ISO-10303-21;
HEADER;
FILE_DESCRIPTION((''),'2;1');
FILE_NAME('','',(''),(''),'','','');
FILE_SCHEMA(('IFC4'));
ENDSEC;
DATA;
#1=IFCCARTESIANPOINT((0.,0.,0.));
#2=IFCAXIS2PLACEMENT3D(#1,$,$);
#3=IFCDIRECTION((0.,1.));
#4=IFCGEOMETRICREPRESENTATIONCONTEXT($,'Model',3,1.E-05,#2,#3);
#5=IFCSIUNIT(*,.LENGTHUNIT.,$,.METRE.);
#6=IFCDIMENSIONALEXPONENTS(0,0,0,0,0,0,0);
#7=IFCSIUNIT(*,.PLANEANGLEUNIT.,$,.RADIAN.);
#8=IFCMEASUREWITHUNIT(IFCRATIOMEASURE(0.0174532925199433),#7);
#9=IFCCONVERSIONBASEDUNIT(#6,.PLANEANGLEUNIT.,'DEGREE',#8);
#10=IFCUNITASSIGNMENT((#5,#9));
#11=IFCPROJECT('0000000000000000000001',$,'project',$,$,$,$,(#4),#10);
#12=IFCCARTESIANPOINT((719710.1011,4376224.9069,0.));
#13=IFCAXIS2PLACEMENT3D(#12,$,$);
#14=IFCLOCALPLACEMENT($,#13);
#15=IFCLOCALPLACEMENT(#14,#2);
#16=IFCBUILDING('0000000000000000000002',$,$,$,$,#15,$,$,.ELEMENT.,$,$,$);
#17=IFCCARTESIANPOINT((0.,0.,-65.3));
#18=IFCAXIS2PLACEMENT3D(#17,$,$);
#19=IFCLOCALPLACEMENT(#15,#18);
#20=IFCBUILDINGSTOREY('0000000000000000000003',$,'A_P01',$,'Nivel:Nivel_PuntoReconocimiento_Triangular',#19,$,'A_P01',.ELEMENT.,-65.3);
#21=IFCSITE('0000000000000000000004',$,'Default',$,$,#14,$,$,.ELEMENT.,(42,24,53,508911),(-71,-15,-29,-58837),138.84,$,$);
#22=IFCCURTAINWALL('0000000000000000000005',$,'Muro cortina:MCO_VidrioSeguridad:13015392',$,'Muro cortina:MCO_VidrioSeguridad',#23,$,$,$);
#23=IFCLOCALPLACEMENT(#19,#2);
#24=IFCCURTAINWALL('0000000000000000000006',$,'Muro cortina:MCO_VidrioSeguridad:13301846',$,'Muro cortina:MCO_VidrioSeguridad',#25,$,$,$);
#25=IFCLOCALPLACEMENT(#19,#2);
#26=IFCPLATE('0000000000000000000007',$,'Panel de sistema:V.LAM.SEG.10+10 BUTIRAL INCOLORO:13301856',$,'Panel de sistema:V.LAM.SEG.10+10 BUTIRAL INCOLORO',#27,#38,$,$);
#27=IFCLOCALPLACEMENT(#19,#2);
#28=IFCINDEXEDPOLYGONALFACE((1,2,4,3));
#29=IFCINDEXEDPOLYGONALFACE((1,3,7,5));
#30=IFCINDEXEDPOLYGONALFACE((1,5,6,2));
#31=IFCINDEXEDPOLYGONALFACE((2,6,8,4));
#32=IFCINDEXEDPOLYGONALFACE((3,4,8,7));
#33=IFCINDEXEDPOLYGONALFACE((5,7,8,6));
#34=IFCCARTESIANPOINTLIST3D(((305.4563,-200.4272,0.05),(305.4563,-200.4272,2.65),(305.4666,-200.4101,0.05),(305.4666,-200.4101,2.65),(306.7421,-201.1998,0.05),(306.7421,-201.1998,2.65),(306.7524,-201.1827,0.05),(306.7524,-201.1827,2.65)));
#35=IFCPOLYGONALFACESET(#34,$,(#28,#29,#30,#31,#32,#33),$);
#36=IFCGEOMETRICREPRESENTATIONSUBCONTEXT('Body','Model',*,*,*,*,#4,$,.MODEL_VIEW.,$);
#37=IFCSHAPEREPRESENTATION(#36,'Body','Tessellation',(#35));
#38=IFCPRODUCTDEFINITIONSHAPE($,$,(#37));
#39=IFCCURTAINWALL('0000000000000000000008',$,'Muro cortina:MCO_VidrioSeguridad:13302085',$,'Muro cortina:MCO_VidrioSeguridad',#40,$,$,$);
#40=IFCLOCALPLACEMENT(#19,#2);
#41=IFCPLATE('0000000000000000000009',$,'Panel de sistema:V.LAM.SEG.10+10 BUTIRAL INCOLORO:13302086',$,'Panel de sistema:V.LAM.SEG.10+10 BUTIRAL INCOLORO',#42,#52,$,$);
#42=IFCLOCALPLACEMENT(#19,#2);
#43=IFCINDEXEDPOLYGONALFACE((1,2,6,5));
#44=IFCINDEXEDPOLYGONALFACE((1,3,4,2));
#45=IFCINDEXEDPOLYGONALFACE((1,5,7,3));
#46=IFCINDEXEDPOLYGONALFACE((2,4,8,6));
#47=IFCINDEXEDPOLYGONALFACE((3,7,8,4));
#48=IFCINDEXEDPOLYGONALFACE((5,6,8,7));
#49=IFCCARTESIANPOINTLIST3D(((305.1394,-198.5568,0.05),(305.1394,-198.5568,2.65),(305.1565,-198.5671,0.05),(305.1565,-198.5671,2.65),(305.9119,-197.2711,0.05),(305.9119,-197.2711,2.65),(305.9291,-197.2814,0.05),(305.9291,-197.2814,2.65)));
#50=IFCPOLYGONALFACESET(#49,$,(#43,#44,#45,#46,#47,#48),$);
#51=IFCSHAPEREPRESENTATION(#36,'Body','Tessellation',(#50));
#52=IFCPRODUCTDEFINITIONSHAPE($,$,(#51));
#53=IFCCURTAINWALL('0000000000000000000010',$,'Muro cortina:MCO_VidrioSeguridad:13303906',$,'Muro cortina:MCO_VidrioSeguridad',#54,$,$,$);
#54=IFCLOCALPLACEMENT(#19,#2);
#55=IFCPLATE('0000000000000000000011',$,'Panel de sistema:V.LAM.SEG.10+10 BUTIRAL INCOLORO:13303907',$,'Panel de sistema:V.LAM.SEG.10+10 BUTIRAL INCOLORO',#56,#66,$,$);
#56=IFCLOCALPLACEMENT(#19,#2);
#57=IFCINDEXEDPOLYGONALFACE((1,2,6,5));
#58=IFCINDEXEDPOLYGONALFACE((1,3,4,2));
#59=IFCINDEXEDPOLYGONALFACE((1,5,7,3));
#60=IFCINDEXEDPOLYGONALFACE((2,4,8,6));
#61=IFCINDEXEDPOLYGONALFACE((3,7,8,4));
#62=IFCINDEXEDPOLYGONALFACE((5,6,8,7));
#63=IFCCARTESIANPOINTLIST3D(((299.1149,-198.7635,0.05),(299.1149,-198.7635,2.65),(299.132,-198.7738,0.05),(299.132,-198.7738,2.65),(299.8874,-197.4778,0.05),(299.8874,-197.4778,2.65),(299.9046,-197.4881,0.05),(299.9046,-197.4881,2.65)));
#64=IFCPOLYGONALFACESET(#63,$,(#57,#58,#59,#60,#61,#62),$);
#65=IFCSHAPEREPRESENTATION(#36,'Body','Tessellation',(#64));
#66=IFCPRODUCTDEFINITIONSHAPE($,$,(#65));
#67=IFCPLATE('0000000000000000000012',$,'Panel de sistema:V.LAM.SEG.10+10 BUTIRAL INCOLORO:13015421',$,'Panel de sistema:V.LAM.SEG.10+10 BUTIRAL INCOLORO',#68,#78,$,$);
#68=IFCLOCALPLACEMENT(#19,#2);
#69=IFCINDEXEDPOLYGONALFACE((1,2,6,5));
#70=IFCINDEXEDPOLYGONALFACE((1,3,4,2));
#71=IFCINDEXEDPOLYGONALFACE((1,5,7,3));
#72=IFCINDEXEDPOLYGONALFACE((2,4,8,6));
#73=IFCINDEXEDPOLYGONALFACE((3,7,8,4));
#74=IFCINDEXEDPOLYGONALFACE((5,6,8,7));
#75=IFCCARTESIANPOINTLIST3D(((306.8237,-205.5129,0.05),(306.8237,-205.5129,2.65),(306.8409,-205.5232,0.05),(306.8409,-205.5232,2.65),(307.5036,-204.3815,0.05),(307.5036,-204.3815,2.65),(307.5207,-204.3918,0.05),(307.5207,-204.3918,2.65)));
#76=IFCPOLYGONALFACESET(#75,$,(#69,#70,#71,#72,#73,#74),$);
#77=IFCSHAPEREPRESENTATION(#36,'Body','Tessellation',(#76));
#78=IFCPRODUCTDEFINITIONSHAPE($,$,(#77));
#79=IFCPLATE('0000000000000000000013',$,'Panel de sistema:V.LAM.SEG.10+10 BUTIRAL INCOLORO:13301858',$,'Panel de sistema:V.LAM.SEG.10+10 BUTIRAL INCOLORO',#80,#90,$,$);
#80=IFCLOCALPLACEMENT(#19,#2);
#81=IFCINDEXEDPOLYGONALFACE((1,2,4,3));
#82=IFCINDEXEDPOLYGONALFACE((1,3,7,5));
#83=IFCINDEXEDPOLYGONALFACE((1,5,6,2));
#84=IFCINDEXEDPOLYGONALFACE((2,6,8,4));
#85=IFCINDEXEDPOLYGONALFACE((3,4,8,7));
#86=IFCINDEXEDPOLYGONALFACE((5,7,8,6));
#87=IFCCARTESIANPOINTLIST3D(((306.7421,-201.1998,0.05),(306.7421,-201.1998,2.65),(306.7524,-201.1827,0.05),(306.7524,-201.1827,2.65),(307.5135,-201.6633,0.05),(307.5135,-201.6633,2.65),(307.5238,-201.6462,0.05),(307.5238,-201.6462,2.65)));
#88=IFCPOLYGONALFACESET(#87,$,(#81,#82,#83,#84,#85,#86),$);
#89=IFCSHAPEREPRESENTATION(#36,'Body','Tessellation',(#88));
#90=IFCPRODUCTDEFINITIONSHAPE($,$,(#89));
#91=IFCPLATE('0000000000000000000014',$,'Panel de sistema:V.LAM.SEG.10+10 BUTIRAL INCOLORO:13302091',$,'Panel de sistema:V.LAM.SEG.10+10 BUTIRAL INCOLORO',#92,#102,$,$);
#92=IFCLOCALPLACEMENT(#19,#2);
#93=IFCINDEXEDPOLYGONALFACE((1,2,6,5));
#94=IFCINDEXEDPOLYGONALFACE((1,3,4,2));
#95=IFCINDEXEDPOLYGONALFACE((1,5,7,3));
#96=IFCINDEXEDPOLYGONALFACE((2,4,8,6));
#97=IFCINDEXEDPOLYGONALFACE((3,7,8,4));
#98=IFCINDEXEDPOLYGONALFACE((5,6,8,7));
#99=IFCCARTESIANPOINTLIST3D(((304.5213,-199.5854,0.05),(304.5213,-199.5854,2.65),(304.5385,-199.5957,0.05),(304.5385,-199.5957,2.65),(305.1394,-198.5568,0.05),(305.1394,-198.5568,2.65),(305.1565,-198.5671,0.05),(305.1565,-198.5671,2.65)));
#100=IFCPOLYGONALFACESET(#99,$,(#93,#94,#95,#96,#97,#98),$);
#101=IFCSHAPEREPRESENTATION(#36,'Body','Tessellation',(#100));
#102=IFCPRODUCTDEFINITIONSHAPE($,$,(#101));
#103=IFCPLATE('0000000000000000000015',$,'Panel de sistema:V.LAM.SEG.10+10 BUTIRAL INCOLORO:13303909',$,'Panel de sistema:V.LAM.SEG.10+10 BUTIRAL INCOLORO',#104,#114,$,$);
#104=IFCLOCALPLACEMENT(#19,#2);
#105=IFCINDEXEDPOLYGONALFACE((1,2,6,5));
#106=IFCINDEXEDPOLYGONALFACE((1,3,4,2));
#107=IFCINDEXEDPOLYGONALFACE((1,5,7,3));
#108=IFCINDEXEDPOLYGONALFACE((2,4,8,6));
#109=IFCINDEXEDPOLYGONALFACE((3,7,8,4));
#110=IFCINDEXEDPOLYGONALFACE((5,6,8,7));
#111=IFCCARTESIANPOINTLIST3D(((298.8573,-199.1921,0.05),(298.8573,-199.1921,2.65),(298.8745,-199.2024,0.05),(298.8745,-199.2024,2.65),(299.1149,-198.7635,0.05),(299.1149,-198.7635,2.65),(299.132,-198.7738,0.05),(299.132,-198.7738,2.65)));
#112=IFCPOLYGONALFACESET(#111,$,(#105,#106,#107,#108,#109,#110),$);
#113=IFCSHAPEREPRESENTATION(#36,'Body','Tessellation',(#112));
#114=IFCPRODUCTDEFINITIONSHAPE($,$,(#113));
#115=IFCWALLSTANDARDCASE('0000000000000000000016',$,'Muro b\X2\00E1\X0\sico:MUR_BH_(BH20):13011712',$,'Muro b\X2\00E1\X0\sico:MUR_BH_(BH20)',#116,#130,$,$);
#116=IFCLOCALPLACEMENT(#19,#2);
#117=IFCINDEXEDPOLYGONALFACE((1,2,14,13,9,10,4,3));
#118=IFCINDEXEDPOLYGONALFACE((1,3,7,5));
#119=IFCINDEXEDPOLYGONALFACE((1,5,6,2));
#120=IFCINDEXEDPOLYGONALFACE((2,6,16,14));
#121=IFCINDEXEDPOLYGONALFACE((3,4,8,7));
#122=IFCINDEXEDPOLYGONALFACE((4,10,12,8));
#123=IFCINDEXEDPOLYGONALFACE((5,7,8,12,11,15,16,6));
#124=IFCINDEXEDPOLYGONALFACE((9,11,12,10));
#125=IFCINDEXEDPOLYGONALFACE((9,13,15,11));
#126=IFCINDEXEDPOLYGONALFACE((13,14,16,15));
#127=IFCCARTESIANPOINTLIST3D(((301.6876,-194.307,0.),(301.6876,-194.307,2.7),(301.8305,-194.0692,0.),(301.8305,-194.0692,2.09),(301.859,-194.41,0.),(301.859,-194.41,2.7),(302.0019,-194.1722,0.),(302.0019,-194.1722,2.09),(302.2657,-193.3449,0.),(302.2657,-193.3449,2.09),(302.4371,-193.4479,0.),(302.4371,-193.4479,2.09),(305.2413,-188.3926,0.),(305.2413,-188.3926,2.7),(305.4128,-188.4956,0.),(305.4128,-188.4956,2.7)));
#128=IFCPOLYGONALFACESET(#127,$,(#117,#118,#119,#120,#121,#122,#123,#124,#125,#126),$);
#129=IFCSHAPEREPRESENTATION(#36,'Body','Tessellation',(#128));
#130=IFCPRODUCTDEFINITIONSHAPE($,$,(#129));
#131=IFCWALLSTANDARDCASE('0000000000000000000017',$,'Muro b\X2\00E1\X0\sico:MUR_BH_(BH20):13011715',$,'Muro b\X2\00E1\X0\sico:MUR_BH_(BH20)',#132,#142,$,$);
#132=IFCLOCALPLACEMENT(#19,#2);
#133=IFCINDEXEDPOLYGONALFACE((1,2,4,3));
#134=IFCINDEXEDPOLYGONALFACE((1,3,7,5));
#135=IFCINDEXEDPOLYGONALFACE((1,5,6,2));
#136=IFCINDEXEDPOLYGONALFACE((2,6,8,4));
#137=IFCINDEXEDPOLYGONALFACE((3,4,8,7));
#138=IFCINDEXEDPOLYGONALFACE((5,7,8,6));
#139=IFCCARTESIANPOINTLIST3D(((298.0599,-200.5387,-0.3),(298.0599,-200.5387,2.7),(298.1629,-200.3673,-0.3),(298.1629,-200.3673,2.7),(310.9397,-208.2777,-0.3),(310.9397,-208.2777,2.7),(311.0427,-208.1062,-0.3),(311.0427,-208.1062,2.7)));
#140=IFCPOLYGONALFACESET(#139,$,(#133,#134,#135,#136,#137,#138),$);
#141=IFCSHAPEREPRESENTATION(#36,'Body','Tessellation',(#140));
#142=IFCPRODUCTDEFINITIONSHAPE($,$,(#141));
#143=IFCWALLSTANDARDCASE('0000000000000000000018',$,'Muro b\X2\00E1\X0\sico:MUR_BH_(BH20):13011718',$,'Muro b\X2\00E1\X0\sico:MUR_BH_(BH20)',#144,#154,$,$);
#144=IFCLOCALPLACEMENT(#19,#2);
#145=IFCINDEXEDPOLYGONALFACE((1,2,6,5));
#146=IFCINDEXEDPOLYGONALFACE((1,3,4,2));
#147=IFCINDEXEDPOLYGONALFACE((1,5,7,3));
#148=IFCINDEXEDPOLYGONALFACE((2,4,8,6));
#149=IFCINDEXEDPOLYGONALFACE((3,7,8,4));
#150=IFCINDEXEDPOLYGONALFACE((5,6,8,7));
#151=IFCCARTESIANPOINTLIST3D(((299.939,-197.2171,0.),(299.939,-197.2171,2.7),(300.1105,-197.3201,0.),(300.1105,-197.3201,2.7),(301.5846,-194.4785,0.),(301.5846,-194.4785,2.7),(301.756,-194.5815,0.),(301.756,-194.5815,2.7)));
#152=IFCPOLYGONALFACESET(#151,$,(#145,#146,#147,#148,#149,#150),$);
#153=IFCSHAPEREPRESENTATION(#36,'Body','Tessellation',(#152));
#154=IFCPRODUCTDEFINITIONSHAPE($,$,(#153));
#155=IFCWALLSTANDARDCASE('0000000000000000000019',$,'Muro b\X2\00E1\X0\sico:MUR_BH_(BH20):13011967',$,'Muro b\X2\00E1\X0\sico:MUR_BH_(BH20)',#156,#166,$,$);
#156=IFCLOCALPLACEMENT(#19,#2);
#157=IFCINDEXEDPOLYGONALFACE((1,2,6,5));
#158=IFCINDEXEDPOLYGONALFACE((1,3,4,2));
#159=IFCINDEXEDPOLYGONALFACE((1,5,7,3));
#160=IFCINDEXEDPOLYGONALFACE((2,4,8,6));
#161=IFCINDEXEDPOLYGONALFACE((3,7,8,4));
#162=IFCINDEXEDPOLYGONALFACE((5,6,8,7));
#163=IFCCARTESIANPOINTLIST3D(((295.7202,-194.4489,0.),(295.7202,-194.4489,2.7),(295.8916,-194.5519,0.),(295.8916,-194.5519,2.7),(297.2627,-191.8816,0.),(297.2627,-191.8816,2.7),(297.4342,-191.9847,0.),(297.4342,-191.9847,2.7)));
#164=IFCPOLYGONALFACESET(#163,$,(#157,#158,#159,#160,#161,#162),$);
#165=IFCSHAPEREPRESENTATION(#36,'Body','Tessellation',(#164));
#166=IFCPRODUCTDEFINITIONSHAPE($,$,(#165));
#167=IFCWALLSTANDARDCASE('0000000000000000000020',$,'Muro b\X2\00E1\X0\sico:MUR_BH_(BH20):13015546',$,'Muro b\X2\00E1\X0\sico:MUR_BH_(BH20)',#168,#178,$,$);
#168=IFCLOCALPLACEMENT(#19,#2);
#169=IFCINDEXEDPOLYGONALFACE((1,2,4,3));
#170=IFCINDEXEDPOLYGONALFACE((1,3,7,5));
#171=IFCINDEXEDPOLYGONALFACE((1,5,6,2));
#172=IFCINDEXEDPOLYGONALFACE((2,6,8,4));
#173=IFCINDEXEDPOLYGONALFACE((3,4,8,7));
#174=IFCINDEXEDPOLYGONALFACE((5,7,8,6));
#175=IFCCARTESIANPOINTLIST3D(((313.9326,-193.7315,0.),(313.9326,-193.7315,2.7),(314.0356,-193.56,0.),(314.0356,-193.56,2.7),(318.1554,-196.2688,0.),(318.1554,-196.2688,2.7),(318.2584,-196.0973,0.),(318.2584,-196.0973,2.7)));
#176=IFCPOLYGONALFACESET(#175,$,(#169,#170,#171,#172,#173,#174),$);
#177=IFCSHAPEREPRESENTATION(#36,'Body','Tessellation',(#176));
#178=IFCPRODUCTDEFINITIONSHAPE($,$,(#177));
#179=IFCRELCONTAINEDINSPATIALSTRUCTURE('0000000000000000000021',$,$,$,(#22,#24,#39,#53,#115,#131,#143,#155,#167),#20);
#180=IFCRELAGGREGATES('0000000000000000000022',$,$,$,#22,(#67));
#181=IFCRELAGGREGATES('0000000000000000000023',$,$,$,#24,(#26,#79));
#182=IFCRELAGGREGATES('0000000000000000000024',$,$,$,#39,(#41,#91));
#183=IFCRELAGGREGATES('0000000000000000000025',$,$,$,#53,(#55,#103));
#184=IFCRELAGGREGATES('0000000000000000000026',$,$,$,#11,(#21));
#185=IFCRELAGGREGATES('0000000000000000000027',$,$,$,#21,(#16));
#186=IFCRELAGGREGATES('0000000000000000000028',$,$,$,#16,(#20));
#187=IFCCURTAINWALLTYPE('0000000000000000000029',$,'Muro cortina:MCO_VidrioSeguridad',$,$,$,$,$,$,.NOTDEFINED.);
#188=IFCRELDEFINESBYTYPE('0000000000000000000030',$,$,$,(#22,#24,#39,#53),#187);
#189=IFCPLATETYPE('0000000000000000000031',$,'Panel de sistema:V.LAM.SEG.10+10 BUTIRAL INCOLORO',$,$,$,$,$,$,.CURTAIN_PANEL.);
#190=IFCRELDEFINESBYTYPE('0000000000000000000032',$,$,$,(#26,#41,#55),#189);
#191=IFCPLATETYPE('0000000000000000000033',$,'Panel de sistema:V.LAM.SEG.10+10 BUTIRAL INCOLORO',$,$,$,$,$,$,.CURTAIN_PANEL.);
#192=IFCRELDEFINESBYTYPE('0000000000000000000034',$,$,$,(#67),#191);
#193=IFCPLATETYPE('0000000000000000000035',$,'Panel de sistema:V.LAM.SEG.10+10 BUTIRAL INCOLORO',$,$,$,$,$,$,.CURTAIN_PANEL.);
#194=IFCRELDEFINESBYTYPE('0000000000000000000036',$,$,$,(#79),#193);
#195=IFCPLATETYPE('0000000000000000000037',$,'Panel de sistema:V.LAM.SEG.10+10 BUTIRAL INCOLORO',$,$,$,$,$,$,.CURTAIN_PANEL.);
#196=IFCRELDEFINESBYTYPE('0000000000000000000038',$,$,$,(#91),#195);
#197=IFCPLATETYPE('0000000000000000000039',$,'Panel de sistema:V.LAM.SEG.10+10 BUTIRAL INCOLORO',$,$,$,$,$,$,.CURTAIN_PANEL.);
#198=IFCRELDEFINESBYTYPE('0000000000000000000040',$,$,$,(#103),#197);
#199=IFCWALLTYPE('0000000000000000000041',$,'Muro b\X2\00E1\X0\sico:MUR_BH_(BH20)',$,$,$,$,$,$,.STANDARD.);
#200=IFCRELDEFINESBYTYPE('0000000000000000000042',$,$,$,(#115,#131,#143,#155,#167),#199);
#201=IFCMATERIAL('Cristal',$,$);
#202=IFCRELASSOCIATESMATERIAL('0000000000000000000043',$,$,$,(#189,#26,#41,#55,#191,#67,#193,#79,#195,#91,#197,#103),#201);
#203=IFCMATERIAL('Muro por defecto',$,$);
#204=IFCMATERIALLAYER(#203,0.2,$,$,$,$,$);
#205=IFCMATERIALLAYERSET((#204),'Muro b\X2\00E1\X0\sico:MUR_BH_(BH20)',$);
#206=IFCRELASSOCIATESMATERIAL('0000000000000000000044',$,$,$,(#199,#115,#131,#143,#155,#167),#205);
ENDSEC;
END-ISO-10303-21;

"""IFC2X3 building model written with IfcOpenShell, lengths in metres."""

from ifc_helpers import new_model, entity, si_unit, converted_unit, direction, frame, frame_2d, origin, origin_2d_with_axis, place, context, subcontext, project, spatial, rectangle, extrude, source, transform, mapped, material, layer, layer_set, layer_usage, type_object, type_shapes, element, aggregate, save


model = new_model("IFC2X3")

# Units and contexts
model_context = context("Model", 3, precision=1e-05, world=origin(), true_north=direction((0.0, 1.0)))
body_context = subcontext(model_context, "Body", "Model", "MODEL_VIEW")
ifc_project = project(units=[si_unit("LENGTHUNIT", "METRE"), converted_unit("PLANEANGLEUNIT", "DEGREE", entity("IfcRatioMeasure", 0.0174532925199433), si_unit("PLANEANGLEUNIT", "RADIAN"), dimensions=[0, 0, 0, 0, 0, 0, 0])], contexts=[model_context])

# Site, building, storey
site_placement = place(None, frame((719710.1011, 4376224.9069, 0.0)))
site = spatial("IfcSite", under=ifc_project, at=site_placement, Name="Default", CompositionType="ELEMENT", RefLatitude=(42, 24, 53, 508911), RefLongitude=(-71, -15, -29, -58837), RefElevation=138.84)
building_placement = place(site_placement, origin())
building = spatial("IfcBuilding", under=site, at=building_placement, CompositionType="ELEMENT")
storey_placement = place(building_placement, frame((0.0, 0.0, -65.3)))
storey = spatial("IfcBuildingStorey", under=building, at=storey_placement, Name="A_P01", ObjectType="Nivel:Nivel_PuntoReconocimiento_Triangular", LongName="A_P01", CompositionType="ELEMENT", Elevation=-65.3)

# Curtain walls, plate
curtain_wall_type = type_object("IfcCurtainWallType", Name="Muro cortina:MCO_VidrioSeguridad", PredefinedType="NOTDEFINED")
ifc_material_1 = material(Name="Cristal")
plate_type_1 = type_object("IfcPlateType", Name="Panel de sistema:V.LAM.SEG.10+10 BUTIRAL INCOLORO", PredefinedType="CURTAIN_PANEL", material=ifc_material_1)
shared_shape_1 = source(origin(), body_context, "Body", "SweptSolid", [
    extrude(rectangle(XDim=0.02, YDim=1.5, at=origin_2d_with_axis()), frame((0.0, 0.0, 0.0), z_axis=(0.0, 0.0, 1.0), x_axis=(0.0, 1.0, 0.0)), (0.0, 0.0, 1.0), 2.6),
])
type_shapes(plate_type_1, [shared_shape_1])
curtain_wall_1_placement = place(storey_placement, frame((0.0, 0.0, 65.3)))
curtain_wall_1 = element("IfcCurtainWall", 1, at=curtain_wall_1_placement, inside=storey, type_object=curtain_wall_type, Name="Muro cortina:MCO_VidrioSeguridad:13015392", ObjectType="Muro cortina:MCO_VidrioSeguridad")
curtain_wall_2_placement = place(storey_placement, frame((0.0, 0.0, 65.3)))
curtain_wall_2 = element("IfcCurtainWall", 2, at=curtain_wall_2_placement, inside=storey, type_object=curtain_wall_type, Name="Muro cortina:MCO_VidrioSeguridad:13301846", ObjectType="Muro cortina:MCO_VidrioSeguridad")
plate_1_placement = place(curtain_wall_2_placement, frame((306.1043, -200.8049, -65.25), z_axis=(0.0, 0.0, 1.0), x_axis=(0.857167, -0.515038, 0.0)))
plate_1 = element("IfcPlate", 3, at=plate_1_placement, type_object=plate_type_1, material=ifc_material_1, Name="Panel de sistema:V.LAM.SEG.10+10 BUTIRAL INCOLORO:13301856", ObjectType="Panel de sistema:V.LAM.SEG.10+10 BUTIRAL INCOLORO", context=body_context, shape_type="MappedRepresentation", body=[
    mapped(shared_shape_1, transform((0.0, 0.0, 0.0), scale=1.0)),
])

# Curtain walls, plates
curtain_wall_3_placement = place(storey_placement, frame((0.0, 0.0, 65.3)))
curtain_wall_3 = element("IfcCurtainWall", 4, at=curtain_wall_3_placement, inside=storey, type_object=curtain_wall_type, Name="Muro cortina:MCO_VidrioSeguridad:13302085", ObjectType="Muro cortina:MCO_VidrioSeguridad")
plate_2_placement = place(curtain_wall_3_placement, frame((305.5342, -197.9191, -65.25), z_axis=(0.0, 0.0, 1.0), x_axis=(-0.515038, -0.857167, 0.0)))
plate_2 = element("IfcPlate", 5, at=plate_2_placement, type_object=plate_type_1, material=ifc_material_1, Name="Panel de sistema:V.LAM.SEG.10+10 BUTIRAL INCOLORO:13302086", ObjectType="Panel de sistema:V.LAM.SEG.10+10 BUTIRAL INCOLORO", context=body_context, shape_type="MappedRepresentation", body=[
    mapped(shared_shape_1, transform((0.0, 0.0, 0.0), scale=1.0)),
])
curtain_wall_4_placement = place(storey_placement, frame((0.0, 0.0, 65.3)))
curtain_wall_4 = element("IfcCurtainWall", 6, at=curtain_wall_4_placement, inside=storey, type_object=curtain_wall_type, Name="Muro cortina:MCO_VidrioSeguridad:13303906", ObjectType="Muro cortina:MCO_VidrioSeguridad")
plate_3_placement = place(curtain_wall_4_placement, frame((299.5097, -198.1258, -65.25), z_axis=(0.0, 0.0, 1.0), x_axis=(-0.515038, -0.857167, 0.0)))
plate_3 = element("IfcPlate", 7, at=plate_3_placement, type_object=plate_type_1, material=ifc_material_1, Name="Panel de sistema:V.LAM.SEG.10+10 BUTIRAL INCOLORO:13303907", ObjectType="Panel de sistema:V.LAM.SEG.10+10 BUTIRAL INCOLORO", context=body_context, shape_type="MappedRepresentation", body=[
    mapped(shared_shape_1, transform((0.0, 0.0, 0.0), scale=1.0)),
])

# Plates
plate_type_2 = type_object("IfcPlateType", Name="Panel de sistema:V.LAM.SEG.10+10 BUTIRAL INCOLORO", PredefinedType="CURTAIN_PANEL", material=ifc_material_1)
shared_shape_2 = source(origin(), body_context, "Body", "SweptSolid", [
    extrude(rectangle(XDim=0.02, YDim=1.32, at=origin_2d_with_axis()), frame((0.0, 0.0, 0.0), z_axis=(0.0, 0.0, 1.0), x_axis=(0.0, 1.0, 0.0)), (0.0, 0.0, 1.0), 2.6),
])
type_shapes(plate_type_2, [shared_shape_2])
plate_4_placement = place(curtain_wall_1_placement, frame((307.1722, -204.9523, -65.25), z_axis=(0.0, 0.0, 1.0), x_axis=(-0.515038, -0.857167, 0.0)))
plate_4 = element("IfcPlate", 8, at=plate_4_placement, type_object=plate_type_2, material=ifc_material_1, Name="Panel de sistema:V.LAM.SEG.10+10 BUTIRAL INCOLORO:13015421", ObjectType="Panel de sistema:V.LAM.SEG.10+10 BUTIRAL INCOLORO", context=body_context, shape_type="MappedRepresentation", body=[
    mapped(shared_shape_2, transform((0.0, 0.0, 0.0), scale=1.0)),
])
aggregate(curtain_wall_1, [plate_4])
plate_type_3 = type_object("IfcPlateType", Name="Panel de sistema:V.LAM.SEG.10+10 BUTIRAL INCOLORO", PredefinedType="CURTAIN_PANEL", material=ifc_material_1)
shared_shape_3 = source(origin(), body_context, "Body", "SweptSolid", [
    extrude(rectangle(XDim=0.02, YDim=0.9, at=origin_2d_with_axis()), frame((0.0, 0.0, 0.0), z_axis=(0.0, 0.0, 1.0), x_axis=(0.0, 1.0, 0.0)), (0.0, 0.0, 1.0), 2.6),
])
type_shapes(plate_type_3, [shared_shape_3])
plate_5_placement = place(curtain_wall_2_placement, frame((307.1329, -201.423, -65.25), z_axis=(0.0, 0.0, 1.0), x_axis=(0.857167, -0.515038, 0.0)))
plate_5 = element("IfcPlate", 9, at=plate_5_placement, type_object=plate_type_3, material=ifc_material_1, Name="Panel de sistema:V.LAM.SEG.10+10 BUTIRAL INCOLORO:13301858", ObjectType="Panel de sistema:V.LAM.SEG.10+10 BUTIRAL INCOLORO", context=body_context, shape_type="MappedRepresentation", body=[
    mapped(shared_shape_3, transform((0.0, 0.0, 0.0), scale=1.0)),
])
aggregate(curtain_wall_2, [plate_1, plate_5])
plate_type_4 = type_object("IfcPlateType", Name="Panel de sistema:V.LAM.SEG.10+10 BUTIRAL INCOLORO", PredefinedType="CURTAIN_PANEL", material=ifc_material_1)
shared_shape_4 = source(origin(), body_context, "Body", "SweptSolid", [
    extrude(rectangle(XDim=0.02, YDim=1.2, at=origin_2d_with_axis()), frame((0.0, 0.0, 0.0), z_axis=(0.0, 0.0, 1.0), x_axis=(0.0, 1.0, 0.0)), (0.0, 0.0, 1.0), 2.6),
])
type_shapes(plate_type_4, [shared_shape_4])
plate_6_placement = place(curtain_wall_3_placement, frame((304.8389, -199.0763, -65.25), z_axis=(0.0, 0.0, 1.0), x_axis=(-0.515038, -0.857167, 0.0)))
plate_6 = element("IfcPlate", 10, at=plate_6_placement, type_object=plate_type_4, material=ifc_material_1, Name="Panel de sistema:V.LAM.SEG.10+10 BUTIRAL INCOLORO:13302091", ObjectType="Panel de sistema:V.LAM.SEG.10+10 BUTIRAL INCOLORO", context=body_context, shape_type="MappedRepresentation", body=[
    mapped(shared_shape_4, transform((0.0, 0.0, 0.0), scale=1.0)),
])
aggregate(curtain_wall_3, [plate_2, plate_6])
plate_type_5 = type_object("IfcPlateType", Name="Panel de sistema:V.LAM.SEG.10+10 BUTIRAL INCOLORO", PredefinedType="CURTAIN_PANEL", material=ifc_material_1)
shared_shape_5 = source(origin(), body_context, "Body", "SweptSolid", [
    extrude(rectangle(XDim=0.02, YDim=0.5, at=origin_2d_with_axis()), frame((0.0, 0.0, 0.0), z_axis=(0.0, 0.0, 1.0), x_axis=(0.0, 1.0, 0.0)), (0.0, 0.0, 1.0), 2.6),
])
type_shapes(plate_type_5, [shared_shape_5])
plate_7_placement = place(curtain_wall_4_placement, frame((298.9947, -198.983, -65.25), z_axis=(0.0, 0.0, 1.0), x_axis=(-0.515038, -0.857167, 0.0)))
plate_7 = element("IfcPlate", 11, at=plate_7_placement, type_object=plate_type_5, material=ifc_material_1, Name="Panel de sistema:V.LAM.SEG.10+10 BUTIRAL INCOLORO:13303909", ObjectType="Panel de sistema:V.LAM.SEG.10+10 BUTIRAL INCOLORO", context=body_context, shape_type="MappedRepresentation", body=[
    mapped(shared_shape_5, transform((0.0, 0.0, 0.0), scale=1.0)),
])
aggregate(curtain_wall_4, [plate_3, plate_7])

# Wall, opening
ifc_material_2 = material(Name="Muro por defecto")
ifc_layer = layer(ifc_material_2, 0.2)
ifc_layer_set = layer_set([ifc_layer], Name="Muro básico:MUR_BH_(BH20)")
ifc_layer_usage_1 = layer_usage(ifc_layer_set, "AXIS2", "NEGATIVE", 0.1)
wall_type = type_object("IfcWallType", Name="Muro básico:MUR_BH_(BH20)", PredefinedType="STANDARD", material=ifc_layer_set)
wall_1_placement = place(storey_placement, frame((301.7733, -194.3585, 0.0), z_axis=(0.0, 0.0, 1.0), x_axis=(0.515038, 0.857167, 0.0)))
wall_1 = element("IfcWallStandardCase", 12, at=wall_1_placement, inside=storey, type_object=wall_type, material=ifc_layer_usage_1, Name="Muro básico:MUR_BH_(BH20):13011712", ObjectType="Muro básico:MUR_BH_(BH20)", context=body_context, shape_type="SweptSolid", body=[
    extrude(rectangle(XDim=6.9, YDim=0.2, at=frame_2d((3.45, 0.0), x_axis=(-1.0, 0.0))), origin(), (0.0, 0.0, 1.0), 2.7),
])
opening_1_placement = place(wall_1_placement, frame((11.173, 358.7722, 0.0), z_axis=(0.0, 0.0, 1.0), x_axis=(0.515038, -0.857167, 0.0)))
element("IfcOpeningElement", 13, at=opening_1_placement, cuts=wall_1, ObjectType="Opening", context=body_context, shape_type="SweptSolid", body=[
    extrude(rectangle(XDim=2.09, YDim=0.845, at=frame_2d((0.0, 0.0), x_axis=(0.0, 1.0))), frame((302.2195, -193.81, 1.045), z_axis=(-0.857167, 0.515038, 0.0), x_axis=(0.515038, 0.857167, 0.0)), (0.0, 0.0, 1.0), 0.2),
])

# Walls
ifc_layer_usage_2 = layer_usage(ifc_layer_set, "AXIS2", "NEGATIVE", 0.1)
wall_2_placement = place(storey_placement, frame((310.9912, -208.192, -0.3), z_axis=(0.0, 0.0, 1.0), x_axis=(-0.857167, 0.515038, 0.0)))
element("IfcWallStandardCase", 14, at=wall_2_placement, inside=storey, type_object=wall_type, material=ifc_layer_usage_2, Name="Muro básico:MUR_BH_(BH20):13011715", ObjectType="Muro básico:MUR_BH_(BH20)", context=body_context, shape_type="SweptSolid", body=[
    extrude(rectangle(XDim=15.026, YDim=0.2, at=frame_2d((7.513, 0.0), x_axis=(-1.0, 0.0))), origin(), (0.0, 0.0, 1.0), 3.0),
])
ifc_layer_usage_3 = layer_usage(ifc_layer_set, "AXIS2", "NEGATIVE", 0.1)
wall_3_placement = place(storey_placement, frame((301.6703, -194.53, 0.0), z_axis=(0.0, 0.0, 1.0), x_axis=(-0.515038, -0.857167, 0.0)))
element("IfcWallStandardCase", 15, at=wall_3_placement, inside=storey, type_object=wall_type, material=ifc_layer_usage_3, Name="Muro básico:MUR_BH_(BH20):13011718", ObjectType="Muro básico:MUR_BH_(BH20)", context=body_context, shape_type="SweptSolid", body=[
    extrude(rectangle(XDim=3.195, YDim=0.2, at=frame_2d((1.5975, 0.0), x_axis=(-1.0, 0.0))), origin(), (0.0, 0.0, 1.0), 2.7),
])

# Walls
ifc_layer_usage_4 = layer_usage(ifc_layer_set, "AXIS2", "NEGATIVE", 0.1)
wall_4_placement = place(storey_placement, frame((297.3485, -191.9332, 0.0), z_axis=(0.0, 0.0, 1.0), x_axis=(-0.515038, -0.857167, 0.0)))
element("IfcWallStandardCase", 16, at=wall_4_placement, inside=storey, type_object=wall_type, material=ifc_layer_usage_4, Name="Muro básico:MUR_BH_(BH20):13011967", ObjectType="Muro básico:MUR_BH_(BH20)", context=body_context, shape_type="SweptSolid", body=[
    extrude(rectangle(XDim=2.995, YDim=0.2, at=frame_2d((1.4975, 0.0), x_axis=(-1.0, 0.0))), origin(), (0.0, 0.0, 1.0), 2.7),
])
ifc_layer_usage_5 = layer_usage(ifc_layer_set, "AXIS2", "NEGATIVE", 0.1)
wall_5_placement = place(storey_placement, frame((313.9841, -193.6457, 0.0), z_axis=(0.0, 0.0, 1.0), x_axis=(0.857167, -0.515038, 0.0)))
element("IfcWallStandardCase", 17, at=wall_5_placement, inside=storey, type_object=wall_type, material=ifc_layer_usage_5, Name="Muro básico:MUR_BH_(BH20):13015546", ObjectType="Muro básico:MUR_BH_(BH20)", context=body_context, shape_type="SweptSolid", body=[
    extrude(rectangle(XDim=4.9264, YDim=0.2, at=frame_2d((2.4632, 0.0), x_axis=(-1.0, 0.0))), origin(), (0.0, 0.0, 1.0), 2.7),
])

save(model, "model.ifc")
